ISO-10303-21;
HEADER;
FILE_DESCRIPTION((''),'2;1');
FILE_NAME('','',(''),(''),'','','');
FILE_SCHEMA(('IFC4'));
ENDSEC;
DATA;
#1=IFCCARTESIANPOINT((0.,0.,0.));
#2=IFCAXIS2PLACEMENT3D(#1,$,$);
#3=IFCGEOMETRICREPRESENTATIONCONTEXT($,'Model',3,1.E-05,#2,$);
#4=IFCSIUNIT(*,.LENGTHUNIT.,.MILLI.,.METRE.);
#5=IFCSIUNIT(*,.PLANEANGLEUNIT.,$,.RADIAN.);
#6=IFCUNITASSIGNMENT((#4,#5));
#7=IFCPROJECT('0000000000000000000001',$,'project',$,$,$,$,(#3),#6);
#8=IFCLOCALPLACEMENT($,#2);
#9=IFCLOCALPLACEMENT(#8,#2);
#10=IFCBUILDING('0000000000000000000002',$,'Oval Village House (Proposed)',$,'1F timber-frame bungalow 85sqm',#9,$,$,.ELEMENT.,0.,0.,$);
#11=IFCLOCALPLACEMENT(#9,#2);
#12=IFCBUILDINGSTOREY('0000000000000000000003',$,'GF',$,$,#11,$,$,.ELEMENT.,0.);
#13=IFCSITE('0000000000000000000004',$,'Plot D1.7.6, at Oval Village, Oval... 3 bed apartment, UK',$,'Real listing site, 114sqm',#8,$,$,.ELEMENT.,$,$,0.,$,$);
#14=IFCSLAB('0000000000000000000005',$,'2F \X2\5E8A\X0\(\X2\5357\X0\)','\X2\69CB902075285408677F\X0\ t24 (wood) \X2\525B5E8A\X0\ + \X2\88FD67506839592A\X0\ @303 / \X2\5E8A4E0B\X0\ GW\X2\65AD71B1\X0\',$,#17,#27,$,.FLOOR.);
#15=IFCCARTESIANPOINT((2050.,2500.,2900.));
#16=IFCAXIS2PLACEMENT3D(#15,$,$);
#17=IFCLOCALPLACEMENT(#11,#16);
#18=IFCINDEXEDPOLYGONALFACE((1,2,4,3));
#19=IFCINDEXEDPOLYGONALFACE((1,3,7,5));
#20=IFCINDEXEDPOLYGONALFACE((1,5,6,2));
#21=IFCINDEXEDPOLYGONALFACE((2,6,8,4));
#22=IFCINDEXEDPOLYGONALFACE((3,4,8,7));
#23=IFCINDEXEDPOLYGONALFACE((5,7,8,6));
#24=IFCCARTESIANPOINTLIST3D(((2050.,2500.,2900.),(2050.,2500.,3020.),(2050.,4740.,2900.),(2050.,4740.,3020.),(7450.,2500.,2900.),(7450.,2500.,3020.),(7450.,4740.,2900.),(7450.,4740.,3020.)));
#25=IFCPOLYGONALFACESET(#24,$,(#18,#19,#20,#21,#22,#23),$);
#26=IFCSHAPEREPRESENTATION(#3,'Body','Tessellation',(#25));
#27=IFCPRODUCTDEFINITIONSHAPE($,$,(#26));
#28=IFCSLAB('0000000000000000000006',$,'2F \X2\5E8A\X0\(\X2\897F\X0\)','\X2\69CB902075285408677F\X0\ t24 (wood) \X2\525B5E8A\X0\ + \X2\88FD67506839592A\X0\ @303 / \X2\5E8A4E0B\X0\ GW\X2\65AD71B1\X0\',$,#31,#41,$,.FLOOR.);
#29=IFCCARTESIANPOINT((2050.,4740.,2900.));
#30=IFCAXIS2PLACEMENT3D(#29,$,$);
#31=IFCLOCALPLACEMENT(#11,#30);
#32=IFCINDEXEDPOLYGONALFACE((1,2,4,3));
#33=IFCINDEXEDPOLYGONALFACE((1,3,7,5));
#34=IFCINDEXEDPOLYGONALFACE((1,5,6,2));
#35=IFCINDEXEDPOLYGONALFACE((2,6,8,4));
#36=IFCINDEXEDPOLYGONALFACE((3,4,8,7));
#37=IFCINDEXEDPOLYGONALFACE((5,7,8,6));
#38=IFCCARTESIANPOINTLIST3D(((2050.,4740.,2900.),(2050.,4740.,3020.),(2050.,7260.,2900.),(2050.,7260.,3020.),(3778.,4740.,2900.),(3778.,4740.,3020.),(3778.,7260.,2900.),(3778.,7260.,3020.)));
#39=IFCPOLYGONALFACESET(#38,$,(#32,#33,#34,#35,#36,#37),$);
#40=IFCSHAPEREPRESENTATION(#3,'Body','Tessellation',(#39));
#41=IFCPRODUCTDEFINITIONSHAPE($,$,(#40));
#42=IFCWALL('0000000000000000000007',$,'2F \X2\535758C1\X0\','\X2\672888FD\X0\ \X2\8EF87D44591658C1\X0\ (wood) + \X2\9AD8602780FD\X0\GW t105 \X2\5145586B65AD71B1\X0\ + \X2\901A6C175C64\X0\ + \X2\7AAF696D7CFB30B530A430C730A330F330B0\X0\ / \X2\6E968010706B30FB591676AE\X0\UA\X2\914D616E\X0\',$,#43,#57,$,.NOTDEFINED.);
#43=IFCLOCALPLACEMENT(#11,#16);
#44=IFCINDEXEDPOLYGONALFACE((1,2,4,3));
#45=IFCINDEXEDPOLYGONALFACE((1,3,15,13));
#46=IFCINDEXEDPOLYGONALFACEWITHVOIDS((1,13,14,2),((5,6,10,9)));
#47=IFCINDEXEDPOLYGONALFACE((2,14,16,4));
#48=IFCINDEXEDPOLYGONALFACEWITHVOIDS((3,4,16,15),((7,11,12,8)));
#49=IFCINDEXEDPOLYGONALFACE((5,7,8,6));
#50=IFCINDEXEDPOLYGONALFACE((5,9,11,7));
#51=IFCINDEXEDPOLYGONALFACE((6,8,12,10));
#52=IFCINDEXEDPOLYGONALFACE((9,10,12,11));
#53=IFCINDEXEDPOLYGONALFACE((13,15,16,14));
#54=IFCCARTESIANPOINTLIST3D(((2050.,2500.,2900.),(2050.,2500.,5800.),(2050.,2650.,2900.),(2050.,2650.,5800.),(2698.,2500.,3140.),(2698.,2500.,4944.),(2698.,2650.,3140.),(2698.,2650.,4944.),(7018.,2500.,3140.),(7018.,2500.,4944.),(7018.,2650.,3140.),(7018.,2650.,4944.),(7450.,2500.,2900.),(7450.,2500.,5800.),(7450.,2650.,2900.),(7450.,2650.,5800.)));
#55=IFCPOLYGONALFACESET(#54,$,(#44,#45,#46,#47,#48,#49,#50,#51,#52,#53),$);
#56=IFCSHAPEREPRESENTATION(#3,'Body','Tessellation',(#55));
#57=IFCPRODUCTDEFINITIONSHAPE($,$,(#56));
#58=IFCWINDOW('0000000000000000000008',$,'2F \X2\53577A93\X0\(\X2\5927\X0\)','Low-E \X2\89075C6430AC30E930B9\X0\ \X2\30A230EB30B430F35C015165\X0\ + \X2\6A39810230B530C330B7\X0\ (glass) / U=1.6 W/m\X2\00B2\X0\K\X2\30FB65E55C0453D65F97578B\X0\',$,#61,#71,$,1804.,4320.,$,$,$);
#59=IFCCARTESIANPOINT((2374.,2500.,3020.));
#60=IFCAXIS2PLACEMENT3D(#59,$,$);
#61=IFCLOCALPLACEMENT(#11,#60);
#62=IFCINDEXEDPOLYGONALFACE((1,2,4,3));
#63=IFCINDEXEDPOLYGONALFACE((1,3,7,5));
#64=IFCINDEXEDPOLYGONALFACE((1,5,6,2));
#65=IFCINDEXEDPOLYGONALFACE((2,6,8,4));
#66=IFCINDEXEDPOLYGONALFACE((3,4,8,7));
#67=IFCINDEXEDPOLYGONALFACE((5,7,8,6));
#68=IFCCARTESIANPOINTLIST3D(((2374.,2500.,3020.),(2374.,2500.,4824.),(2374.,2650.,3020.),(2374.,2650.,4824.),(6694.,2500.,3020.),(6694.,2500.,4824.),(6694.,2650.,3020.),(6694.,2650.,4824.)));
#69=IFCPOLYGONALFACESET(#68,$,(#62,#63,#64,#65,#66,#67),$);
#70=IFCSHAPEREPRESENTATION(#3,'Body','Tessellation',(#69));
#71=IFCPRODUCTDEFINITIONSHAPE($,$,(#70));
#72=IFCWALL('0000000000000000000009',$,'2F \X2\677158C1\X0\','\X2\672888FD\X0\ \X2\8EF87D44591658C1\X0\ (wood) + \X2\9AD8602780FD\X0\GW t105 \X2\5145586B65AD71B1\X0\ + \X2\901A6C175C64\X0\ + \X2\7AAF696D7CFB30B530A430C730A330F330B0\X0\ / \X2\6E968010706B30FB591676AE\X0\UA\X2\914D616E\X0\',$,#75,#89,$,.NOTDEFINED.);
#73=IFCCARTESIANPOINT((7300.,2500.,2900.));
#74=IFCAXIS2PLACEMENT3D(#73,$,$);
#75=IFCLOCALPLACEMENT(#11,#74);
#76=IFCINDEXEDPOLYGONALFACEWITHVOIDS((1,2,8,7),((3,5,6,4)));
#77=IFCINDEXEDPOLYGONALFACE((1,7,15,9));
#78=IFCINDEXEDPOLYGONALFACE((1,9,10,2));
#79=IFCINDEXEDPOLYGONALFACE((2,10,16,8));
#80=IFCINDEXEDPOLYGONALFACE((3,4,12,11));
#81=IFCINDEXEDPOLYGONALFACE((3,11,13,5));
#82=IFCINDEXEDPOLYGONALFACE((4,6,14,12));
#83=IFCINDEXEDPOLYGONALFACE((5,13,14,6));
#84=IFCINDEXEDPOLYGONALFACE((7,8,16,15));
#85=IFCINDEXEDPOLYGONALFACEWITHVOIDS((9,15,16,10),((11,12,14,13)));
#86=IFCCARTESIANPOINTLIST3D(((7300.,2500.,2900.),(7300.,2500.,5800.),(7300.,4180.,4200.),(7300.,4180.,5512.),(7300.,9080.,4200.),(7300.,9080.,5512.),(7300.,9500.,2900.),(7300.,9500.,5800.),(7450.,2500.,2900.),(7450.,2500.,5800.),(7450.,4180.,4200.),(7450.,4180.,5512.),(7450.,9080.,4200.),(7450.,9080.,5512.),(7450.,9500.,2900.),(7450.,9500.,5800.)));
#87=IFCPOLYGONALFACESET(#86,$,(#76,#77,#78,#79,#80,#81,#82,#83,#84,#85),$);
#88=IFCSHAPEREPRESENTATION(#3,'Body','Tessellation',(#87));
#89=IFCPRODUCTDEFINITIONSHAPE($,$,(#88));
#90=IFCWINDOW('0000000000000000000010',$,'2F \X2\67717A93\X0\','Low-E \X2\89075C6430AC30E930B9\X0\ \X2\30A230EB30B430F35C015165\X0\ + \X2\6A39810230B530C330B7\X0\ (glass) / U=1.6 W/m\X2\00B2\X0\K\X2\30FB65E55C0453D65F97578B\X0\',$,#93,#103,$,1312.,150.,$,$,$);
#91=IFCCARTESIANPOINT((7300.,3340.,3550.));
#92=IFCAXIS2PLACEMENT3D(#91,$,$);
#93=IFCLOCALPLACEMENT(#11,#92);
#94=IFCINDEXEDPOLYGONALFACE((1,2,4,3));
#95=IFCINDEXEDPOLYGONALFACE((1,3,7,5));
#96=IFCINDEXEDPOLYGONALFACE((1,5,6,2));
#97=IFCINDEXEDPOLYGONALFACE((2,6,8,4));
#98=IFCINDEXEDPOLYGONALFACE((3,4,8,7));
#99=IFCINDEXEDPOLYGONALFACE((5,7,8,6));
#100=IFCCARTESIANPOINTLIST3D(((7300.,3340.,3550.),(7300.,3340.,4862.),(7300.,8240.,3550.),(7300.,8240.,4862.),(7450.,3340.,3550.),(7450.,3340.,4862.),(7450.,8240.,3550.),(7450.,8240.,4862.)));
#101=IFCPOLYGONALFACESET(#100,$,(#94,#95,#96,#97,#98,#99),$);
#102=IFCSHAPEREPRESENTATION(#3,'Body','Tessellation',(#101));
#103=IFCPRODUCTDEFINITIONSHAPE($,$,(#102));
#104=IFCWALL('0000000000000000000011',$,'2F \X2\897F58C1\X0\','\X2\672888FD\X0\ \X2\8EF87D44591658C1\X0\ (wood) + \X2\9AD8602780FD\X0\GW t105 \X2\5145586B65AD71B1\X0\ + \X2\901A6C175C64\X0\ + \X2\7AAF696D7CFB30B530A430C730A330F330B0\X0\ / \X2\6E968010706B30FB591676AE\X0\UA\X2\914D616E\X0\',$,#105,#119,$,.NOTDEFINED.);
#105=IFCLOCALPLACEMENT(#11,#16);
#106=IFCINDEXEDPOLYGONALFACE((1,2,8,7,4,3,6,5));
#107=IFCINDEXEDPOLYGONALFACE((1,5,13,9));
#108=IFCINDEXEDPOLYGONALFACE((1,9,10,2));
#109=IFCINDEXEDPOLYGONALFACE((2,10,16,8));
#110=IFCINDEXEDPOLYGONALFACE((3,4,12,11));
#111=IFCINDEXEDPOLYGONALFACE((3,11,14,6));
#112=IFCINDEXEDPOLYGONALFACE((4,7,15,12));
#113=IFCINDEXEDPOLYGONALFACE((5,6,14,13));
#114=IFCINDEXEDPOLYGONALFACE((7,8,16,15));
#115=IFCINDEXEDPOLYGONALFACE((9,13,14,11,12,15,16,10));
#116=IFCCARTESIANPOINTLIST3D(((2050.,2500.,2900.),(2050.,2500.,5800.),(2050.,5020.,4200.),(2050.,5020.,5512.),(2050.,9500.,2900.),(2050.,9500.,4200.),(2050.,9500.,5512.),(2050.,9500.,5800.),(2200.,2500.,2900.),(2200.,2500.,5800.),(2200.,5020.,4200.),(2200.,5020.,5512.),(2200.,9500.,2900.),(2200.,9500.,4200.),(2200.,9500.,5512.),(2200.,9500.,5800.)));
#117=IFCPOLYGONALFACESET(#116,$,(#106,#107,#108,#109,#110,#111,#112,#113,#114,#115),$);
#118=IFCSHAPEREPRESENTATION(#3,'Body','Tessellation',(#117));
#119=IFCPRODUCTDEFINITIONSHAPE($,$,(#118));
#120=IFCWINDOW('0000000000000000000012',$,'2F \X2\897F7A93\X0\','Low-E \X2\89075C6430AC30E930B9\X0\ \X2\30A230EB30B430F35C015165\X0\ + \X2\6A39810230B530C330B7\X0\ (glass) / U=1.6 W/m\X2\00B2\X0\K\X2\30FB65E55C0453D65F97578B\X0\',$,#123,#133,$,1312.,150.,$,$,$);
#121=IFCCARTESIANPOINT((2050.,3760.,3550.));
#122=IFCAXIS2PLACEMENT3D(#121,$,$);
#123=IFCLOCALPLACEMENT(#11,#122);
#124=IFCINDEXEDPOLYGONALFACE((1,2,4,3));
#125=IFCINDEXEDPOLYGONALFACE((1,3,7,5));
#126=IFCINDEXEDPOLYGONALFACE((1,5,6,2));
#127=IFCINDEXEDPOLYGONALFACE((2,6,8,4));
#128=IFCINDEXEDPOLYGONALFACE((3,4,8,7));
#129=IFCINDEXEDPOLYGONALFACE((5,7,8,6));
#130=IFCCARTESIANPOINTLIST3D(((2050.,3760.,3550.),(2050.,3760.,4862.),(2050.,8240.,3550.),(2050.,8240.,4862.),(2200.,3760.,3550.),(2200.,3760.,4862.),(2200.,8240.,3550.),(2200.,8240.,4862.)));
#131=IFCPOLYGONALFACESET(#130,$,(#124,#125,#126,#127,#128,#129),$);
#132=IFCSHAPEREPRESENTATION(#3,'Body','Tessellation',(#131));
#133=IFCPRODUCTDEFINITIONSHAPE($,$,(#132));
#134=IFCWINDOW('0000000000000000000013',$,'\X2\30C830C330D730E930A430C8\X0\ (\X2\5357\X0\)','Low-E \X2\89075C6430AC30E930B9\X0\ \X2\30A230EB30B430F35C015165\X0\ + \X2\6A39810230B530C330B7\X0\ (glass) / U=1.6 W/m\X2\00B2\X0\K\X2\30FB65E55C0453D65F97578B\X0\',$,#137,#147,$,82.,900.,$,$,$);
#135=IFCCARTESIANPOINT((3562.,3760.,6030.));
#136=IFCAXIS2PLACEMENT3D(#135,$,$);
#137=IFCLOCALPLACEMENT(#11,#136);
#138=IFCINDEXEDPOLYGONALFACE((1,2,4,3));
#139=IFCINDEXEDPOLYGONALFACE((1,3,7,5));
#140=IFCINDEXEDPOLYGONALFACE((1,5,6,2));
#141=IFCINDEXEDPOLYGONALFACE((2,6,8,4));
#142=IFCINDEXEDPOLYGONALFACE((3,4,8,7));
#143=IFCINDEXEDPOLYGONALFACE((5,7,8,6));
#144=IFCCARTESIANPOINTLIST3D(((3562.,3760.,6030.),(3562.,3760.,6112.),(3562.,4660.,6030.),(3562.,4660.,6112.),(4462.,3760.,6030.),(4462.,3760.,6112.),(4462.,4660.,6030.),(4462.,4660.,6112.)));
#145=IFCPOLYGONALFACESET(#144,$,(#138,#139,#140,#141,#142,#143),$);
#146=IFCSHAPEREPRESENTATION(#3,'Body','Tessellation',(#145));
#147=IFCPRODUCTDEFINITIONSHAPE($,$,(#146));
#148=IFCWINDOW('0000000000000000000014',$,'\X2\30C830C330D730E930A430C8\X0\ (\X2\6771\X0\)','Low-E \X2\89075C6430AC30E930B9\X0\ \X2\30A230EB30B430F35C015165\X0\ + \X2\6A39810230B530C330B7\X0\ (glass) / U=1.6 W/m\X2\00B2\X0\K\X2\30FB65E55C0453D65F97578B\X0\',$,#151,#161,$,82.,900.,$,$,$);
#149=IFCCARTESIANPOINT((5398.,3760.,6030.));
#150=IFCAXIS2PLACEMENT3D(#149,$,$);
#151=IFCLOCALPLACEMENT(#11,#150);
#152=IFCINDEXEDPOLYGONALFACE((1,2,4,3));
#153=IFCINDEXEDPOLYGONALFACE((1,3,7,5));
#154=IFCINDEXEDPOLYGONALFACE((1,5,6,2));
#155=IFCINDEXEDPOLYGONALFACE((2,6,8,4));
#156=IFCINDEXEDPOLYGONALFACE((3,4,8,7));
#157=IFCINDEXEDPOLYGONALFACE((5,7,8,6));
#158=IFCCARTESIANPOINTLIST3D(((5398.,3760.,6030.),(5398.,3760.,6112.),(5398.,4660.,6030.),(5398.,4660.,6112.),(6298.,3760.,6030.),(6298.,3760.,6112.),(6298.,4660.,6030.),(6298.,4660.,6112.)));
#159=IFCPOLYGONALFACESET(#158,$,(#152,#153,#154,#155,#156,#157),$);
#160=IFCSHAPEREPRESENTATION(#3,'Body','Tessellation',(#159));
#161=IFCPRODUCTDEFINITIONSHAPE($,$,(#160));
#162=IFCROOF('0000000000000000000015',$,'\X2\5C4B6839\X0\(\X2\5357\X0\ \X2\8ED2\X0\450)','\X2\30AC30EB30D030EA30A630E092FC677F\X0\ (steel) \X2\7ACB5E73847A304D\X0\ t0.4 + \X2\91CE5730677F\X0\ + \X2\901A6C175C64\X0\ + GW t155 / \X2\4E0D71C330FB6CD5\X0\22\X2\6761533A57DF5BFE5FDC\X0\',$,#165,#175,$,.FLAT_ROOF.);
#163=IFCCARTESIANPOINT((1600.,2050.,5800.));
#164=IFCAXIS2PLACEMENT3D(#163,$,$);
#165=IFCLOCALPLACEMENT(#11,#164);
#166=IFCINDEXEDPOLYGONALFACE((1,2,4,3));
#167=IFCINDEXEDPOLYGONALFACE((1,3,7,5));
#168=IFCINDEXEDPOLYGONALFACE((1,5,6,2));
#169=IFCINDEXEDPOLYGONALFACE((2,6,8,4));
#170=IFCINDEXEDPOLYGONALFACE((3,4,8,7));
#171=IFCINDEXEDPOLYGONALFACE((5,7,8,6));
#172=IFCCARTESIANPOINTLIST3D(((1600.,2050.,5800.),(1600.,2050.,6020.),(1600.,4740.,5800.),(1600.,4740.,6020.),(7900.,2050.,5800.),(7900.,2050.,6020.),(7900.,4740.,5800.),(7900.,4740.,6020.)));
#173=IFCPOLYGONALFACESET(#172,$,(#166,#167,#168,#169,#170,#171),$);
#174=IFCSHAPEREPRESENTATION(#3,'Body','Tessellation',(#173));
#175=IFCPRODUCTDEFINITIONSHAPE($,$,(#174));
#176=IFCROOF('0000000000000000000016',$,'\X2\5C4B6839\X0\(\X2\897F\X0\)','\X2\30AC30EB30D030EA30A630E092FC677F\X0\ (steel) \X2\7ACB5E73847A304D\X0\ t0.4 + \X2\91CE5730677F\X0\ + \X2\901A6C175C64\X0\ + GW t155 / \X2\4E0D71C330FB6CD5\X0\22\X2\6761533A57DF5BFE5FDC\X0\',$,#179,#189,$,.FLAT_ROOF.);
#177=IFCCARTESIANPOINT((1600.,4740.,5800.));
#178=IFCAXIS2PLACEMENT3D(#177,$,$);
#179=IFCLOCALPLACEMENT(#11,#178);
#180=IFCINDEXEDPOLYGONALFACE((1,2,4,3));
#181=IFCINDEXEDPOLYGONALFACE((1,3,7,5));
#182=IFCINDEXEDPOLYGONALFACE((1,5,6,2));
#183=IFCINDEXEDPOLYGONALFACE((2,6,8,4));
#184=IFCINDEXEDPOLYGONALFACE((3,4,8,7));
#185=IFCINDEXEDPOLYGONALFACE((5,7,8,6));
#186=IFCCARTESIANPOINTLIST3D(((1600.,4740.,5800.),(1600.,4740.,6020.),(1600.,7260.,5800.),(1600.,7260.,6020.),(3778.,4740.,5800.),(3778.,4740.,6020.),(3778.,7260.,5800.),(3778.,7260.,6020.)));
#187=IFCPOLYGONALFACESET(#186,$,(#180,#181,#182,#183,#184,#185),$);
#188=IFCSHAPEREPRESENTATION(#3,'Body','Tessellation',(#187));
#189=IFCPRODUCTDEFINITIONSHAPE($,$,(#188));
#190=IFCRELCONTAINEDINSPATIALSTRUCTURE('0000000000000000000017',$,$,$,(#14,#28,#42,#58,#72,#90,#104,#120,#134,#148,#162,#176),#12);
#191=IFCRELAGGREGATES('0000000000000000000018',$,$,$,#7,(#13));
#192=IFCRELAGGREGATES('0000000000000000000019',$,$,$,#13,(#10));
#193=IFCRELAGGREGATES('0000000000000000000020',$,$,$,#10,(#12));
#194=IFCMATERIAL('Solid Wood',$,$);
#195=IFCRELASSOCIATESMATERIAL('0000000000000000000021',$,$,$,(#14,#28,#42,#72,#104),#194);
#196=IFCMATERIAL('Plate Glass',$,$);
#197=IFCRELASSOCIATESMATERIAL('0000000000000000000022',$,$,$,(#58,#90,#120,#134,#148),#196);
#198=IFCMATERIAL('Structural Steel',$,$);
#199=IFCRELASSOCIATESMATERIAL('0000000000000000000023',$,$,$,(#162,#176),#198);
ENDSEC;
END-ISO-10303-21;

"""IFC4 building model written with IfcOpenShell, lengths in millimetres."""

from ifc_helpers import new_model, si_unit, frame, frame_2d, origin, place, context, project, spatial, rectangle, extrude, material, element, fill, save


model = new_model("IFC4")

# Units and contexts
model_context = context("Model", 3, precision=1e-05, world=origin())
ifc_project = project(units=[si_unit("LENGTHUNIT", "METRE", prefix="MILLI"), si_unit("PLANEANGLEUNIT", "RADIAN")], contexts=[model_context])

# Site, building, storey
site_placement = place(None, origin())
site = spatial("IfcSite", under=ifc_project, at=site_placement, Name="Plot D1.7.6, at Oval Village, Oval... 3 bed apartment, UK", ObjectType="Real listing site, 114sqm", CompositionType="ELEMENT", RefElevation=0.0)
building_placement = place(site_placement, origin())
building = spatial("IfcBuilding", under=site, at=building_placement, Name="Oval Village House (Proposed)", ObjectType="1F timber-frame bungalow 85sqm", CompositionType="ELEMENT", ElevationOfRefHeight=0.0, ElevationOfTerrain=0.0)
storey_placement = place(building_placement, origin())
storey = spatial("IfcBuildingStorey", under=building, at=storey_placement, Name="GF", CompositionType="ELEMENT", Elevation=0.0)

# Slabs
ifc_material_1 = material(Name="Solid Wood")
slab_1_placement = place(storey_placement, frame((2050.0, 2500.0, 2900.0)))
element("IfcSlab", 1, at=slab_1_placement, inside=storey, material=ifc_material_1, Name="2F 床(南)", Description="構造用合板 t24 (wood) 剛床 + 製材根太 @303 / 床下 GW断熱", PredefinedType="FLOOR", context=model_context, shape_type="SweptSolid", body=[
    extrude(rectangle(XDim=5400.0, YDim=2240.0, at=frame_2d((2700.0, 1120.0))), frame((2050.0, 2500.0, 2900.0)), (0.0, 0.0, 1.0), 120.0),
])
slab_2_placement = place(storey_placement, frame((2050.0, 4740.0, 2900.0)))
element("IfcSlab", 2, at=slab_2_placement, inside=storey, material=ifc_material_1, Name="2F 床(西)", Description="構造用合板 t24 (wood) 剛床 + 製材根太 @303 / 床下 GW断熱", PredefinedType="FLOOR", context=model_context, shape_type="SweptSolid", body=[
    extrude(rectangle(XDim=1728.0, YDim=2520.0, at=frame_2d((864.0, 1260.0))), frame((2050.0, 4740.0, 2900.0)), (0.0, 0.0, 1.0), 120.0),
])

# Walls, openings, windows
wall_1_placement = place(storey_placement, frame((2050.0, 2500.0, 2900.0)))
wall_1 = element("IfcWall", 3, at=wall_1_placement, inside=storey, material=ifc_material_1, Name="2F 南壁", Description="木製 軸組外壁 (wood) + 高性能GW t105 充填断熱 + 通気層 + 窯業系サイディング / 準耐火・外皮UA配慮", PredefinedType="NOTDEFINED", context=model_context, shape_type="SweptSolid", body=[
    extrude(rectangle(XDim=5400.0, YDim=150.0, at=frame_2d((2700.0, 75.0))), frame((2050.0, 2500.0, 2900.0)), (0.0, 0.0, 1.0), 2900.0),
])
opening_1_placement = place(storey_placement, frame((2374.0, 2500.0, 3020.0)))
opening_1 = element("IfcOpeningElement", 4, at=opening_1_placement, cuts=wall_1, PredefinedType="NOTDEFINED", context=model_context, shape_type="SweptSolid", body=[
    extrude(rectangle(XDim=4320.0, YDim=150.0, at=frame_2d((2160.0, 75.0))), frame((2374.0, 2500.0, 3020.0)), (0.0, 0.0, 1.0), 1804.0),
])
ifc_material_2 = material(Name="Plate Glass")
window_1_placement = place(storey_placement, frame((2374.0, 2500.0, 3020.0)))
window_1 = element("IfcWindow", 5, at=window_1_placement, inside=storey, material=ifc_material_2, Name="2F 南窓(大)", Description="Low-E 複層ガラス アルゴン封入 + 樹脂サッシ (glass) / U=1.6 W/m²K・日射取得型", OverallHeight=1804.0, OverallWidth=4320.0, context=model_context, shape_type="SweptSolid", body=[
    extrude(rectangle(XDim=4320.0, YDim=150.0, at=frame_2d((2160.0, 75.0))), frame((2374.0, 2500.0, 3020.0)), (0.0, 0.0, 1.0), 1804.0),
])
fill(opening_1, window_1)
wall_2_placement = place(storey_placement, frame((7300.0, 2500.0, 2900.0)))
wall_2 = element("IfcWall", 6, at=wall_2_placement, inside=storey, material=ifc_material_1, Name="2F 東壁", Description="木製 軸組外壁 (wood) + 高性能GW t105 充填断熱 + 通気層 + 窯業系サイディング / 準耐火・外皮UA配慮", PredefinedType="NOTDEFINED", context=model_context, shape_type="SweptSolid", body=[
    extrude(rectangle(XDim=150.0, YDim=7000.0, at=frame_2d((75.0, 3500.0))), frame((7300.0, 2500.0, 2900.0)), (0.0, 0.0, 1.0), 2900.0),
])
opening_2_placement = place(storey_placement, frame((7300.0, 3340.0, 3550.0)))
opening_2 = element("IfcOpeningElement", 7, at=opening_2_placement, cuts=wall_2, PredefinedType="NOTDEFINED", context=model_context, shape_type="SweptSolid", body=[
    extrude(rectangle(XDim=150.0, YDim=4900.0, at=frame_2d((75.0, 2450.0))), frame((7300.0, 3340.0, 3550.0)), (0.0, 0.0, 1.0), 1312.0),
])
window_2_placement = place(storey_placement, frame((7300.0, 3340.0, 3550.0)))
window_2 = element("IfcWindow", 8, at=window_2_placement, inside=storey, material=ifc_material_2, Name="2F 東窓", Description="Low-E 複層ガラス アルゴン封入 + 樹脂サッシ (glass) / U=1.6 W/m²K・日射取得型", OverallHeight=1312.0, OverallWidth=150.0, context=model_context, shape_type="SweptSolid", body=[
    extrude(rectangle(XDim=150.0, YDim=4900.0, at=frame_2d((75.0, 2450.0))), frame((7300.0, 3340.0, 3550.0)), (0.0, 0.0, 1.0), 1312.0),
])
fill(opening_2, window_2)
wall_3_placement = place(storey_placement, frame((2050.0, 2500.0, 2900.0)))
wall_3 = element("IfcWall", 9, at=wall_3_placement, inside=storey, material=ifc_material_1, Name="2F 西壁", Description="木製 軸組外壁 (wood) + 高性能GW t105 充填断熱 + 通気層 + 窯業系サイディング / 準耐火・外皮UA配慮", PredefinedType="NOTDEFINED", context=model_context, shape_type="SweptSolid", body=[
    extrude(rectangle(XDim=150.0, YDim=7000.0, at=frame_2d((75.0, 3500.0))), frame((2050.0, 2500.0, 2900.0)), (0.0, 0.0, 1.0), 2900.0),
])
opening_3_placement = place(storey_placement, frame((2050.0, 3760.0, 3550.0)))
opening_3 = element("IfcOpeningElement", 10, at=opening_3_placement, cuts=wall_3, PredefinedType="NOTDEFINED", context=model_context, shape_type="SweptSolid", body=[
    extrude(rectangle(XDim=150.0, YDim=4480.0, at=frame_2d((75.0, 2240.0))), frame((2050.0, 3760.0, 3550.0)), (0.0, 0.0, 1.0), 1312.0),
])
window_3_placement = place(storey_placement, frame((2050.0, 3760.0, 3550.0)))
window_3 = element("IfcWindow", 11, at=window_3_placement, inside=storey, material=ifc_material_2, Name="2F 西窓", Description="Low-E 複層ガラス アルゴン封入 + 樹脂サッシ (glass) / U=1.6 W/m²K・日射取得型", OverallHeight=1312.0, OverallWidth=150.0, context=model_context, shape_type="SweptSolid", body=[
    extrude(rectangle(XDim=150.0, YDim=4480.0, at=frame_2d((75.0, 2240.0))), frame((2050.0, 3760.0, 3550.0)), (0.0, 0.0, 1.0), 1312.0),
])
fill(opening_3, window_3)

# Windows
window_4_placement = place(storey_placement, frame((3562.0, 3760.0, 6030.0)))
element("IfcWindow", 12, at=window_4_placement, inside=storey, material=ifc_material_2, Name="トップライト (南)", Description="Low-E 複層ガラス アルゴン封入 + 樹脂サッシ (glass) / U=1.6 W/m²K・日射取得型", OverallHeight=82.0, OverallWidth=900.0, context=model_context, shape_type="SweptSolid", body=[
    extrude(rectangle(XDim=900.0, YDim=900.0, at=frame_2d((450.0, 450.0))), frame((3562.0, 3760.0, 6030.0)), (0.0, 0.0, 1.0), 82.0),
])
window_5_placement = place(storey_placement, frame((5398.0, 3760.0, 6030.0)))
element("IfcWindow", 13, at=window_5_placement, inside=storey, material=ifc_material_2, Name="トップライト (東)", Description="Low-E 複層ガラス アルゴン封入 + 樹脂サッシ (glass) / U=1.6 W/m²K・日射取得型", OverallHeight=82.0, OverallWidth=900.0, context=model_context, shape_type="SweptSolid", body=[
    extrude(rectangle(XDim=900.0, YDim=900.0, at=frame_2d((450.0, 450.0))), frame((5398.0, 3760.0, 6030.0)), (0.0, 0.0, 1.0), 82.0),
])

# Roofs
ifc_material_3 = material(Name="Structural Steel")
roof_1_placement = place(storey_placement, frame((1600.0, 2050.0, 5800.0)))
element("IfcRoof", 14, at=roof_1_placement, inside=storey, material=ifc_material_3, Name="屋根(南 軒450)", Description="ガルバリウム鋼板 (steel) 立平葺き t0.4 + 野地板 + 通気層 + GW t155 / 不燃・法22条区域対応", PredefinedType="FLAT_ROOF", context=model_context, shape_type="SweptSolid", body=[
    extrude(rectangle(XDim=6300.0, YDim=2690.0, at=frame_2d((3150.0, 1345.0))), frame((1600.0, 2050.0, 5800.0)), (0.0, 0.0, 1.0), 220.0),
])
roof_2_placement = place(storey_placement, frame((1600.0, 4740.0, 5800.0)))
element("IfcRoof", 15, at=roof_2_placement, inside=storey, material=ifc_material_3, Name="屋根(西)", Description="ガルバリウム鋼板 (steel) 立平葺き t0.4 + 野地板 + 通気層 + GW t155 / 不燃・法22条区域対応", PredefinedType="FLAT_ROOF", context=model_context, shape_type="SweptSolid", body=[
    extrude(rectangle(XDim=2178.0, YDim=2520.0, at=frame_2d((1089.0, 1260.0))), frame((1600.0, 4740.0, 5800.0)), (0.0, 0.0, 1.0), 220.0),
])

save(model, "model.ifc")
